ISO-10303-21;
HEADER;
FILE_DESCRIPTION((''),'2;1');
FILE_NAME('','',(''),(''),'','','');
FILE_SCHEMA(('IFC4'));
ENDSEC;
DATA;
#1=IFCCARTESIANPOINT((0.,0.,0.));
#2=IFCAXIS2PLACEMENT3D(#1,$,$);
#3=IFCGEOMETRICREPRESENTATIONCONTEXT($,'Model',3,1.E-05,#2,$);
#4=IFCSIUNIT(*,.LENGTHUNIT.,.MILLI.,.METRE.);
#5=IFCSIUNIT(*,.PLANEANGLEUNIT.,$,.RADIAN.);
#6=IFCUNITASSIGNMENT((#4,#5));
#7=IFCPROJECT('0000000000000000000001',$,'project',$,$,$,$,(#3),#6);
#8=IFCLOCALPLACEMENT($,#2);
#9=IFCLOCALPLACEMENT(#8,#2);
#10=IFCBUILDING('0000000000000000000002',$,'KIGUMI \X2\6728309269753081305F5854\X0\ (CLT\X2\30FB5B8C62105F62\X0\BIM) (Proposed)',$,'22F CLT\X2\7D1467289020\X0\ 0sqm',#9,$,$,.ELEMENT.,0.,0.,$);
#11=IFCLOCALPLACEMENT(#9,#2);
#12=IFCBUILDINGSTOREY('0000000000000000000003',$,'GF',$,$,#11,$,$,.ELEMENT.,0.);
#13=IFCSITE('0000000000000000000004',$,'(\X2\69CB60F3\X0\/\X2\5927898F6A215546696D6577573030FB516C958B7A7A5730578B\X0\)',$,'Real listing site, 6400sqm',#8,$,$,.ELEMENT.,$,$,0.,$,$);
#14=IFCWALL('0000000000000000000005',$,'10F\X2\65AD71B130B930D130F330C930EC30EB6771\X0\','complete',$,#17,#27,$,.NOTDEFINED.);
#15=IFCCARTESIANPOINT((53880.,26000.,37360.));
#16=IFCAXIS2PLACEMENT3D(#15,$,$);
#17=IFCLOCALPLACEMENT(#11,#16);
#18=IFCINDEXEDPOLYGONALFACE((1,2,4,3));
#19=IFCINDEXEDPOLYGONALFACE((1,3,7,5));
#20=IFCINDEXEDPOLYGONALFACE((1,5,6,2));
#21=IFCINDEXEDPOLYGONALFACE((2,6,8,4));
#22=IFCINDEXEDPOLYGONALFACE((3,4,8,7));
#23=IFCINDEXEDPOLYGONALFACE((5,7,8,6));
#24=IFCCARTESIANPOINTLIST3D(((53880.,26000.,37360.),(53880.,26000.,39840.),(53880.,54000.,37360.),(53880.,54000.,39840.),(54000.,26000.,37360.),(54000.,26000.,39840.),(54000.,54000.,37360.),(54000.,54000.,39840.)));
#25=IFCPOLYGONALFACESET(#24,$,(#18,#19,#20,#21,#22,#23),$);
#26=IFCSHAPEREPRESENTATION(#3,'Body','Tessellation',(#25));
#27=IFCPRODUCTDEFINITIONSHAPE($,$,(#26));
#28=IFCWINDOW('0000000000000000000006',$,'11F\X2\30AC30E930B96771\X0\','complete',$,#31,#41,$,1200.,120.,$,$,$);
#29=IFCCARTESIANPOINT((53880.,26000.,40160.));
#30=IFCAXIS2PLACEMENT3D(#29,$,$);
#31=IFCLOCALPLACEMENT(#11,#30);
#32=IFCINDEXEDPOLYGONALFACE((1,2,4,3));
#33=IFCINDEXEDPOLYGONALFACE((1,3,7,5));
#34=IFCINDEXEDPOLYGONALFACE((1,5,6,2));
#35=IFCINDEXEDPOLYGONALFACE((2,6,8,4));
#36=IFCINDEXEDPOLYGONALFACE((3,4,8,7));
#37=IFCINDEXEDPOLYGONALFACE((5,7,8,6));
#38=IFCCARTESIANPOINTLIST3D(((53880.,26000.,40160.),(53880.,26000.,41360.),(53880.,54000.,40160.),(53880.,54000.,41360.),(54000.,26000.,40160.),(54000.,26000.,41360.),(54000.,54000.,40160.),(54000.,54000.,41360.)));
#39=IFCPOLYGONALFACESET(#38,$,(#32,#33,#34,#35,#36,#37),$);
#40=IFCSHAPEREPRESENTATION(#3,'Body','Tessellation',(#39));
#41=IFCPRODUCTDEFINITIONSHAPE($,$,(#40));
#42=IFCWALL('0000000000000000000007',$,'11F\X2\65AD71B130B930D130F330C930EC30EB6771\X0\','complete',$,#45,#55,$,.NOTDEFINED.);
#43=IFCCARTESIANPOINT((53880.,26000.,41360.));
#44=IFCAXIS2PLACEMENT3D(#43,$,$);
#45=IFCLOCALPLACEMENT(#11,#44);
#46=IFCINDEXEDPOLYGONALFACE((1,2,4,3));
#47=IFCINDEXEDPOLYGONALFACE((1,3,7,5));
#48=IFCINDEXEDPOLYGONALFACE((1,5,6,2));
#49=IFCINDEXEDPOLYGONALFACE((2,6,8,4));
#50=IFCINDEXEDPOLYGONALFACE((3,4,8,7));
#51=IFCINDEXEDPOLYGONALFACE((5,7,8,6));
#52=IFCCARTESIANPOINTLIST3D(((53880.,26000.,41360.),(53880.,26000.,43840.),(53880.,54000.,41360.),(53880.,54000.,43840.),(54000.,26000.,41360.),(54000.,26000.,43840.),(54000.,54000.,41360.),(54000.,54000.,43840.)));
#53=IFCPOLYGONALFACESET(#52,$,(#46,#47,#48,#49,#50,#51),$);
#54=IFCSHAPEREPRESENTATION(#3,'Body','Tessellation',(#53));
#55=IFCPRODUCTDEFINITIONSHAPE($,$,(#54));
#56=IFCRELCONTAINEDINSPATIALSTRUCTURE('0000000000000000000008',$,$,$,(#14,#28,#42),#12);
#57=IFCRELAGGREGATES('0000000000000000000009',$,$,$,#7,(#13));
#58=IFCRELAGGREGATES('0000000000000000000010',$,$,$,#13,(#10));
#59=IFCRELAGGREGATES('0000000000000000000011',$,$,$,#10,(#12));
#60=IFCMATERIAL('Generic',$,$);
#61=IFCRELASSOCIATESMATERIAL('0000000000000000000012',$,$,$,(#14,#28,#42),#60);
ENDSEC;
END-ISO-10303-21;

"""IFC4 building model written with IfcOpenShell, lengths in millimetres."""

from ifc_helpers import new_model, si_unit, frame, frame_2d, origin, place, context, project, spatial, rectangle, extrude, material, element, save


model = new_model("IFC4")

# Units and contexts
model_context = context("Model", 3, precision=1e-05, world=origin())
ifc_project = project(units=[si_unit("LENGTHUNIT", "METRE", prefix="MILLI"), si_unit("PLANEANGLEUNIT", "RADIAN")], contexts=[model_context])

# Site, building, storey
site_placement = place(None, origin())
site = spatial("IfcSite", under=ifc_project, at=site_placement, Name="(構想/大規模商業敷地・公開空地型)", ObjectType="Real listing site, 6400sqm", CompositionType="ELEMENT", RefElevation=0.0)
building_placement = place(site_placement, origin())
building = spatial("IfcBuilding", under=site, at=building_placement, Name="KIGUMI 木を極めた塔 (CLT・完成形BIM) (Proposed)", ObjectType="22F CLT純木造 0sqm", CompositionType="ELEMENT", ElevationOfRefHeight=0.0, ElevationOfTerrain=0.0)
storey_placement = place(building_placement, origin())
storey = spatial("IfcBuildingStorey", under=building, at=storey_placement, Name="GF", CompositionType="ELEMENT", Elevation=0.0)

# Shared definitions
ifc_material = material(Name="Generic")

# Wall
wall_1_placement = place(storey_placement, frame((53880.0, 26000.0, 37360.0)))
element("IfcWall", 1, at=wall_1_placement, inside=storey, material=ifc_material, Name="10F断熱スパンドレル東", Description="complete", PredefinedType="NOTDEFINED", context=model_context, shape_type="SweptSolid", body=[
    extrude(rectangle(XDim=120.0, YDim=28000.0, at=frame_2d((60.0, 14000.0))), frame((53880.0, 26000.0, 37360.0)), (0.0, 0.0, 1.0), 2480.0),
])

# Window
window_1_placement = place(storey_placement, frame((53880.0, 26000.0, 40160.0)))
element("IfcWindow", 2, at=window_1_placement, inside=storey, material=ifc_material, Name="11Fガラス東", Description="complete", OverallHeight=1200.0, OverallWidth=120.0, context=model_context, shape_type="SweptSolid", body=[
    extrude(rectangle(XDim=120.0, YDim=28000.0, at=frame_2d((60.0, 14000.0))), frame((53880.0, 26000.0, 40160.0)), (0.0, 0.0, 1.0), 1200.0),
])

# Wall
wall_2_placement = place(storey_placement, frame((53880.0, 26000.0, 41360.0)))
element("IfcWall", 3, at=wall_2_placement, inside=storey, material=ifc_material, Name="11F断熱スパンドレル東", Description="complete", PredefinedType="NOTDEFINED", context=model_context, shape_type="SweptSolid", body=[
    extrude(rectangle(XDim=120.0, YDim=28000.0, at=frame_2d((60.0, 14000.0))), frame((53880.0, 26000.0, 41360.0)), (0.0, 0.0, 1.0), 2480.0),
])

save(model, "model.ifc")
